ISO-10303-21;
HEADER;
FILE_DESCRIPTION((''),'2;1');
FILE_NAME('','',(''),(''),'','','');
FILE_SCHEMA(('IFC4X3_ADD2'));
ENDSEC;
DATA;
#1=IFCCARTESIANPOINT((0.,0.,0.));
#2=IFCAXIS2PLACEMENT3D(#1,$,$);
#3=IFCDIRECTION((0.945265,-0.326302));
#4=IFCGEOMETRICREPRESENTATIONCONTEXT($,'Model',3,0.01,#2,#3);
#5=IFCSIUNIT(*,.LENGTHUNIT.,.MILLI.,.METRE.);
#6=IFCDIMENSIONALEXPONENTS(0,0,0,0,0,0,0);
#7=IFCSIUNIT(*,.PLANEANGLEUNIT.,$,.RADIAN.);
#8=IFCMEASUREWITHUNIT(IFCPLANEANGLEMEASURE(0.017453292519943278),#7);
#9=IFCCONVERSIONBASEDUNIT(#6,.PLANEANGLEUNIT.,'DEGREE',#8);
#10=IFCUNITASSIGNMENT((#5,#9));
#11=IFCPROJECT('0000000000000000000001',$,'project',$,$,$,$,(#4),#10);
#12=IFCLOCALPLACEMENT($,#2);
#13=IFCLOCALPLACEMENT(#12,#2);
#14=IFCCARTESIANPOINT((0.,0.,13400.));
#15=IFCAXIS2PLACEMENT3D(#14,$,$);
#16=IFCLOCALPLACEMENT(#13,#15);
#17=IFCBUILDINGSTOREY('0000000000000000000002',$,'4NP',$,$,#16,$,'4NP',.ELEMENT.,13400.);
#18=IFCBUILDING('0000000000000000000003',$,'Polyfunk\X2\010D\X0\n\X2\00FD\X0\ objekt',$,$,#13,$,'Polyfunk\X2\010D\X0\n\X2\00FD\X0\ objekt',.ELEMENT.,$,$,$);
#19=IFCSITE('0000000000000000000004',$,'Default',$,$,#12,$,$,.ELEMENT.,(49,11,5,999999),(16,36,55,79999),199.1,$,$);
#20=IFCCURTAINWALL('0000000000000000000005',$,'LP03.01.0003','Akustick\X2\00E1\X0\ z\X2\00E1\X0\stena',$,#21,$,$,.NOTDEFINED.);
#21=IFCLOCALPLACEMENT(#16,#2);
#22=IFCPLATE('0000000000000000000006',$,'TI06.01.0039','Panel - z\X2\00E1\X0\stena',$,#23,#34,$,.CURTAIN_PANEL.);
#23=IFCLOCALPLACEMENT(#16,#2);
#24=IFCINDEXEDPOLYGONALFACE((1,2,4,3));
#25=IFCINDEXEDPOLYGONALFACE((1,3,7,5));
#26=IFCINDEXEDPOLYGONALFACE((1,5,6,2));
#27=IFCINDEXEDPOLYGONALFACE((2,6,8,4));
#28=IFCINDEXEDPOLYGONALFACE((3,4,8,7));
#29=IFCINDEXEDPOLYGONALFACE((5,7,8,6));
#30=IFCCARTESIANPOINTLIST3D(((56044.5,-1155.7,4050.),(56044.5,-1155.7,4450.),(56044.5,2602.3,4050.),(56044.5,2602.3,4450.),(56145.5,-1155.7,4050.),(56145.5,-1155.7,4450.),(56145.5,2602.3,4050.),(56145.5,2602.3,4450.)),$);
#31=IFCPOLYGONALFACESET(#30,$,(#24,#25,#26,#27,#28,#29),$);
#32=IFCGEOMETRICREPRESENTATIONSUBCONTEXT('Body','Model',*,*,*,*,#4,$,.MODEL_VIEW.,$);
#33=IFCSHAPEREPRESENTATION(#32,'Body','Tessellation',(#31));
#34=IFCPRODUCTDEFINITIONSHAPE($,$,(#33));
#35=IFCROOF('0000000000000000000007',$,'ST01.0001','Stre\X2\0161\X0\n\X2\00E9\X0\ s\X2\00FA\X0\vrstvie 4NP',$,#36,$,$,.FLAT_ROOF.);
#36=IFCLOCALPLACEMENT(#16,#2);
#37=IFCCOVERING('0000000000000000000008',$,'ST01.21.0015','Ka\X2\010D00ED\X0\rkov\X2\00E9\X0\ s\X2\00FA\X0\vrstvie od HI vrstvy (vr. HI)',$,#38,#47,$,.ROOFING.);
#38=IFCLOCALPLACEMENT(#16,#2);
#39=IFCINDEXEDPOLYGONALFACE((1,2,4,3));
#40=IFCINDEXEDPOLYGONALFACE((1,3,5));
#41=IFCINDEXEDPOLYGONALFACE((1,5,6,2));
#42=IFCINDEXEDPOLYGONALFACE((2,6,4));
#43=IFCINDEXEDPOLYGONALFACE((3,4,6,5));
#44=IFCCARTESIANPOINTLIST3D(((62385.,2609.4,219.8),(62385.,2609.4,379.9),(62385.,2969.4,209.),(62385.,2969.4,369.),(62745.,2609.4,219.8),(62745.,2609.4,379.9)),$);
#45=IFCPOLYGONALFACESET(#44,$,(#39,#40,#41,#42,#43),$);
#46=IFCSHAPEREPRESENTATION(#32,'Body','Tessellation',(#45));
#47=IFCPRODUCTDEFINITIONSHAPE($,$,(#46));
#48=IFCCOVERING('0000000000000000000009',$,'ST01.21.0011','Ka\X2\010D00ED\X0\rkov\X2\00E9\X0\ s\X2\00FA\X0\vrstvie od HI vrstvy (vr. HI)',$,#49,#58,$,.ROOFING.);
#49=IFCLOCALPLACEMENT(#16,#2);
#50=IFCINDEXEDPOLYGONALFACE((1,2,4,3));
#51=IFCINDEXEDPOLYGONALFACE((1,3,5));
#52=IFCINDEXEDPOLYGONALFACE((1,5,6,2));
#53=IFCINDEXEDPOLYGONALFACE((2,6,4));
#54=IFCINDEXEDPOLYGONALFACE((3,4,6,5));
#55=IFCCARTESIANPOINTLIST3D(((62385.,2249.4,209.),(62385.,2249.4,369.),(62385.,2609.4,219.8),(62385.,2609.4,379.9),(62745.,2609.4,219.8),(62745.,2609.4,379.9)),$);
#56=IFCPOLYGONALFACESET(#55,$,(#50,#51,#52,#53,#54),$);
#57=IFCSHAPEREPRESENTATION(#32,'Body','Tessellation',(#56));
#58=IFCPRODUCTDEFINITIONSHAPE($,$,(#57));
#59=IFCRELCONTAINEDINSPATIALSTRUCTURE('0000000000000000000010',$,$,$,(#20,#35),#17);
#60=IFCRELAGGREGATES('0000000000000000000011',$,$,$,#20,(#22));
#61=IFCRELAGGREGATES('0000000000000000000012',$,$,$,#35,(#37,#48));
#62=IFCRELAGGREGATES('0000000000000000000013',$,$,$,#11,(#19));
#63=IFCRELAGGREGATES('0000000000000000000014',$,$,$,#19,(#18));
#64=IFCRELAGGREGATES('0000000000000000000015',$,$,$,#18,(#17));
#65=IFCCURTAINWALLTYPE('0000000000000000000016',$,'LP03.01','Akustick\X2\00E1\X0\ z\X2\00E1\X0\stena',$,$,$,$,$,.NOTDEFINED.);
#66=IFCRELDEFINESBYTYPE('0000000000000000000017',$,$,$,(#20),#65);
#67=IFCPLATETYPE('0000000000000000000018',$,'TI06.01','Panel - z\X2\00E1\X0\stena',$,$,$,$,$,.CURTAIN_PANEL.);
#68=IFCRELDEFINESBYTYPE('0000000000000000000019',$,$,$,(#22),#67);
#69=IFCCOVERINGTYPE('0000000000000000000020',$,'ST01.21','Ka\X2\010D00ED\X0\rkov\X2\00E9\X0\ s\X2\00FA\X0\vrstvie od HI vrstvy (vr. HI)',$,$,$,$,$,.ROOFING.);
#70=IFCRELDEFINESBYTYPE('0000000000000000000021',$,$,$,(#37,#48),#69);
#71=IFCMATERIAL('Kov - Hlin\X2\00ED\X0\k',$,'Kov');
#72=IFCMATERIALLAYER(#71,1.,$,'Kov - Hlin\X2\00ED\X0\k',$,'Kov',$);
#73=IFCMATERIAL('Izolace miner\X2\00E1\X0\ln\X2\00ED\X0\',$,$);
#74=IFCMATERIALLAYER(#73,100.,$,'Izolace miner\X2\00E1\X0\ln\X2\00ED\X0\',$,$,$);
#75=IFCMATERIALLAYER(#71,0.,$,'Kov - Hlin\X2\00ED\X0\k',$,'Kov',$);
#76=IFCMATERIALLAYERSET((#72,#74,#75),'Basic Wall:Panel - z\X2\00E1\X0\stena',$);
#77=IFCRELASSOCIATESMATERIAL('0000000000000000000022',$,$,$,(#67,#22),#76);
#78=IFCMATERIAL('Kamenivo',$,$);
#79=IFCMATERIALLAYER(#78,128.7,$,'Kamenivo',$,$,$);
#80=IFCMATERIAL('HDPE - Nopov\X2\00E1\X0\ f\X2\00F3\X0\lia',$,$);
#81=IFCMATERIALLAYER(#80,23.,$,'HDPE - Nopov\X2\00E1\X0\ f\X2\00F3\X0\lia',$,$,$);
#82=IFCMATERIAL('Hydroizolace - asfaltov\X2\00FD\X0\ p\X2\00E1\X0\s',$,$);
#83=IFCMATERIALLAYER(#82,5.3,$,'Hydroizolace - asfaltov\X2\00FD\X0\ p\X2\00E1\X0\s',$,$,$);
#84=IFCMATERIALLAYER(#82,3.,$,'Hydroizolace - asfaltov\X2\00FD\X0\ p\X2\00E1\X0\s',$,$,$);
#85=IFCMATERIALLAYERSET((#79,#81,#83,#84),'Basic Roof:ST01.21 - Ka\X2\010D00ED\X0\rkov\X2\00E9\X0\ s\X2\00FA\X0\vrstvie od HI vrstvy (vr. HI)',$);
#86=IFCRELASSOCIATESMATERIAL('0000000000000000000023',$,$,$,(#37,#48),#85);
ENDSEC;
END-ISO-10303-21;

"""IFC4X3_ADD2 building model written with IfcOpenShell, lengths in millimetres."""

from ifc_helpers import new_model, entity, si_unit, converted_unit, direction, frame, frame_2d, origin, place, context, subcontext, project, spatial, polyline, rectangle, outline, extrude, material, layer, layer_set, layer_usage, type_object, element, aggregate, save


model = new_model("IFC4X3_ADD2")

# Units and contexts
model_context = context("Model", 3, precision=0.01, world=origin(), true_north=direction((0.945265, -0.326302)))
body_context = subcontext(model_context, "Body", "Model", "MODEL_VIEW")
ifc_project = project(units=[si_unit("LENGTHUNIT", "METRE", prefix="MILLI"), converted_unit("PLANEANGLEUNIT", "DEGREE", entity("IfcPlaneAngleMeasure", 0.017453292519943278), si_unit("PLANEANGLEUNIT", "RADIAN"), dimensions=[0, 0, 0, 0, 0, 0, 0])], contexts=[model_context])

# Site, building, storey
site_placement = place(None, origin())
site = spatial("IfcSite", under=ifc_project, at=site_placement, Name="Default", CompositionType="ELEMENT", RefLatitude=(49, 11, 5, 999999), RefLongitude=(16, 36, 55, 79999), RefElevation=199.1)
building_placement = place(site_placement, origin())
building = spatial("IfcBuilding", under=site, at=building_placement, Name="Polyfunkčný objekt", LongName="Polyfunkčný objekt", CompositionType="ELEMENT")
storey_placement = place(building_placement, frame((0.0, 0.0, 13400.0)))
storey = spatial("IfcBuildingStorey", under=building, at=storey_placement, Name="4NP", LongName="4NP", CompositionType="ELEMENT", Elevation=13400.0)

# Curtain wall
curtain_wall_type = type_object("IfcCurtainWallType", Name="LP03.01", Description="Akustická zástena", PredefinedType="NOTDEFINED")
curtain_wall_1_placement = place(storey_placement, frame((0.0, 0.0, -13400.0)))
curtain_wall_1 = element("IfcCurtainWall", 1, at=curtain_wall_1_placement, inside=storey, type_object=curtain_wall_type, Name="LP03.01.0003", Description="Akustická zástena", PredefinedType="NOTDEFINED")

# Shared definitions
ifc_material_1 = material(Name="Kov - Hliník", Category="Kov")
ifc_layer_1 = layer(ifc_material_1, 1.0, Name="Kov - Hliník", Category="Kov")
ifc_material_2 = material(Name="Izolace minerální")
ifc_layer_2 = layer(ifc_material_2, 100.0, Name="Izolace minerální")
ifc_layer_3 = layer(ifc_material_1, 0.0, Name="Kov - Hliník", Category="Kov")
ifc_layer_set_1 = layer_set([ifc_layer_1, ifc_layer_2, ifc_layer_3], Name="Basic Wall:Panel - zástena")
plate_type = type_object("IfcPlateType", Name="TI06.01", Description="Panel - zástena", PredefinedType="CURTAIN_PANEL", material=ifc_layer_set_1)

# Plate
ifc_layer_usage_1 = layer_usage(ifc_layer_set_1, "AXIS2", "NEGATIVE", 50.5)
plate_1_placement = place(storey_placement, frame((56095.0, -1155.7, 4050.0), z_axis=(0.0, 0.0, 1.0), x_axis=(0.0, 1.0, 0.0)))
plate_1 = element("IfcPlate", 2, at=plate_1_placement, type_object=plate_type, material=ifc_layer_usage_1, Name="TI06.01.0039", Description="Panel - zástena", PredefinedType="CURTAIN_PANEL", context=body_context, shape_type="SweptSolid", body=[
    extrude(rectangle(XDim=101.0, YDim=3758.1, at=frame_2d((0.0, 0.0), x_axis=(1.0, 0.0))), frame((1879.0, 0.0, 0.0), z_axis=(0.0, 0.0, 1.0), x_axis=(0.0, 1.0, 0.0)), (0.0, 0.0, 1.0), 400.0),
])
aggregate(curtain_wall_1, [plate_1])

# Roof, coverings
roof = element("IfcRoof", 3, inside=storey, Name="ST01.0001", Description="Strešné súvrstvie 4NP", PredefinedType="FLAT_ROOF")
ifc_material_3 = material(Name="Kamenivo")
ifc_layer_4 = layer(ifc_material_3, 128.7, Name="Kamenivo")
ifc_material_4 = material(Name="HDPE - Nopová fólia")
ifc_layer_5 = layer(ifc_material_4, 23.0, Name="HDPE - Nopová fólia")
ifc_material_5 = material(Name="Hydroizolace - asfaltový pás")
ifc_layer_6 = layer(ifc_material_5, 5.3, Name="Hydroizolace - asfaltový pás")
ifc_layer_7 = layer(ifc_material_5, 3.0, Name="Hydroizolace - asfaltový pás")
ifc_layer_set_2 = layer_set([ifc_layer_4, ifc_layer_5, ifc_layer_6, ifc_layer_7], Name="Basic Roof:ST01.21 - Kačírkové súvrstvie od HI vrstvy (vr. HI)")
covering_type = type_object("IfcCoveringType", Name="ST01.21", Description="Kačírkové súvrstvie od HI vrstvy (vr. HI)", PredefinedType="ROOFING")
placement_1 = place(storey_placement, frame((62385.0, 2609.4, 209.0)))
covering_1_placement = place(placement_1, origin())
covering_1 = element("IfcCovering", 4, at=covering_1_placement, type_object=covering_type, material=ifc_layer_set_2, Name="ST01.21.0015", Description="Kačírkové súvrstvie od HI vrstvy (vr. HI)", PredefinedType="ROOFING", context=body_context, shape_type="SweptSolid", body=[
    extrude(outline(polyline([(180.0, -180.1), (-180.0, 180.1), (-180.0, -180.1), (180.0, -180.1)])), frame((180.0, 180.0, 5.4), z_axis=(0.0, 0.030015, 0.999549), x_axis=(1.0, 0.0, 0.0)), (0.0, -0.030015, 0.999549), 160.1),
])
placement_2 = place(storey_placement, frame((62385.0, 2249.4, 209.0)))
covering_2_placement = place(placement_2, origin())
covering_2 = element("IfcCovering", 5, at=covering_2_placement, type_object=covering_type, material=ifc_layer_set_2, Name="ST01.21.0011", Description="Kačírkové súvrstvie od HI vrstvy (vr. HI)", PredefinedType="ROOFING", context=body_context, shape_type="SweptSolid", body=[
    extrude(outline(polyline([(-180.0, 180.1), (-180.0, -180.1), (180.0, 180.1), (-180.0, 180.1)])), frame((180.0, 180.0, 5.4), z_axis=(0.0, -0.030015, 0.999549), x_axis=(1.0, 0.0, 0.0)), (0.0, 0.030015, 0.999549), 160.1),
])
aggregate(roof, [covering_1, covering_2])

save(model, "model.ifc")
